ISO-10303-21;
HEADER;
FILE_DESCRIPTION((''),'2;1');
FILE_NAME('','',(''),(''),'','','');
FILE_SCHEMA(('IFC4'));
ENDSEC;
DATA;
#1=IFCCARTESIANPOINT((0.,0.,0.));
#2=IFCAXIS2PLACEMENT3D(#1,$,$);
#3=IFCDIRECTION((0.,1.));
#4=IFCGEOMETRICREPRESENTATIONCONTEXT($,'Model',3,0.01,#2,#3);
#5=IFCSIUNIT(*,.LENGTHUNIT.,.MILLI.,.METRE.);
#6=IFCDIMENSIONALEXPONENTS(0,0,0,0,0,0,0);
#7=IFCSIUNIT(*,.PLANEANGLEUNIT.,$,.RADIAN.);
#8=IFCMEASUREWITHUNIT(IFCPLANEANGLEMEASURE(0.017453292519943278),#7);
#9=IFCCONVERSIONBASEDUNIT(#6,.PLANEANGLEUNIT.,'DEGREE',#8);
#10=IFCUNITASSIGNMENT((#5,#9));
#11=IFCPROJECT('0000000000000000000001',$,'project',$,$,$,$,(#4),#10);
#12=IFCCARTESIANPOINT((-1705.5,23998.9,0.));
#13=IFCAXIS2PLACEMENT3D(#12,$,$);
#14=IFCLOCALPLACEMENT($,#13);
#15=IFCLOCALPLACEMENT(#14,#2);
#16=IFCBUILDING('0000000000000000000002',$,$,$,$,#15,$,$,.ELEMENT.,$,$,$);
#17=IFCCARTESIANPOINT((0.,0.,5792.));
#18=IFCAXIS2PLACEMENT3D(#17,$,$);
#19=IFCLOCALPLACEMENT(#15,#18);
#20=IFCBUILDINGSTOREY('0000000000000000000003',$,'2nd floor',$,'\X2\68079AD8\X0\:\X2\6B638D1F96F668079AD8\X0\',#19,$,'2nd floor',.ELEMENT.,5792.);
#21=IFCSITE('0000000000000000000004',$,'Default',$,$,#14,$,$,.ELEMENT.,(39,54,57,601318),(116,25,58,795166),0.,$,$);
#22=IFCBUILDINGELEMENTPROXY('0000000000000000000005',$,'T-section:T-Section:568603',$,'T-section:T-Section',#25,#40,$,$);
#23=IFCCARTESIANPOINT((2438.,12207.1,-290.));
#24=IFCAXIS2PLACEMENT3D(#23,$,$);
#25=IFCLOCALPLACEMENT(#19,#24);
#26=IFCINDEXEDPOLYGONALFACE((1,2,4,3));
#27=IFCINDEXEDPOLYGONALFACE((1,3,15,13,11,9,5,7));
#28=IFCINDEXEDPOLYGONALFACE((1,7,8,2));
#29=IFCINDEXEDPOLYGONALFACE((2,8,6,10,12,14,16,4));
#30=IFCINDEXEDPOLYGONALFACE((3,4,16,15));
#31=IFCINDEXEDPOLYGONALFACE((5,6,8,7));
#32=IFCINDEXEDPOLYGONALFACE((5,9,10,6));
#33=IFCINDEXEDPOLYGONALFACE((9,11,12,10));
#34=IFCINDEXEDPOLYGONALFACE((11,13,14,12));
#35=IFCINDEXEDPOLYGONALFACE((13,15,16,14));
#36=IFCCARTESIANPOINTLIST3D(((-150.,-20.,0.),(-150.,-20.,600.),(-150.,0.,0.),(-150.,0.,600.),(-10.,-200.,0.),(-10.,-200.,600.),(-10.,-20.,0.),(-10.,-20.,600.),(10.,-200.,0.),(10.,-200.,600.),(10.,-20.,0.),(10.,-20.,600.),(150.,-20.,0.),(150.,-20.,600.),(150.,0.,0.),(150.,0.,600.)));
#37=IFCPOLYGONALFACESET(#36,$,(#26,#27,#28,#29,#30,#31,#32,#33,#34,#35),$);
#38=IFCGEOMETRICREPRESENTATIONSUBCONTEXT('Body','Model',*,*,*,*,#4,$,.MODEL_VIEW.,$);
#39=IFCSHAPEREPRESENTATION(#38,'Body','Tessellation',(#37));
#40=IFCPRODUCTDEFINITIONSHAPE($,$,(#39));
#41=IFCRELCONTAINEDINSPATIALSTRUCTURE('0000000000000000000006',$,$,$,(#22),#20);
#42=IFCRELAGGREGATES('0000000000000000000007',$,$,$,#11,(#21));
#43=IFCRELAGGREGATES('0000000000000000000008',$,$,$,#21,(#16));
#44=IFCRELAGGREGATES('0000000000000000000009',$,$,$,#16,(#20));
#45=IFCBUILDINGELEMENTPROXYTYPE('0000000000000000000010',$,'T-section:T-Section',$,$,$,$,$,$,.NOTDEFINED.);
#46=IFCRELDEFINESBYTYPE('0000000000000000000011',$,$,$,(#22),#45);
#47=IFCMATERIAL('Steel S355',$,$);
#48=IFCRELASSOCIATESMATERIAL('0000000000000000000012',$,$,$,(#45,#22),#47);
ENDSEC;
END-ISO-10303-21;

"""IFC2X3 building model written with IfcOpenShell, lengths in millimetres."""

from ifc_helpers import new_model, entity, si_unit, converted_unit, direction, frame, origin, place, context, subcontext, project, spatial, polyline, outline, extrude, source, transform, mapped, material, type_object, type_shapes, element, save


model = new_model("IFC2X3")

# Units and contexts
model_context = context("Model", 3, precision=0.01, world=origin(), true_north=direction((0.0, 1.0)))
body_context = subcontext(model_context, "Body", "Model", "MODEL_VIEW")
ifc_project = project(units=[si_unit("LENGTHUNIT", "METRE", prefix="MILLI"), converted_unit("PLANEANGLEUNIT", "DEGREE", entity("IfcPlaneAngleMeasure", 0.017453292519943278), si_unit("PLANEANGLEUNIT", "RADIAN"), dimensions=[0, 0, 0, 0, 0, 0, 0])], contexts=[model_context])

# Site, building, storey
site_placement = place(None, frame((-1705.5, 23998.9, 0.0)))
site = spatial("IfcSite", under=ifc_project, at=site_placement, Name="Default", CompositionType="ELEMENT", RefLatitude=(39, 54, 57, 601318), RefLongitude=(116, 25, 58, 795166), RefElevation=0.0)
building_placement = place(site_placement, origin())
building = spatial("IfcBuilding", under=site, at=building_placement, CompositionType="ELEMENT")
storey_placement = place(building_placement, frame((0.0, 0.0, 5792.0)))
storey = spatial("IfcBuildingStorey", under=building, at=storey_placement, Name="2nd floor", ObjectType="标高:正负零标高", LongName="2nd floor", CompositionType="ELEMENT", Elevation=5792.0)

# Shared definitions
ifc_material_1 = material(Name="Steel S355")

# Building element proxy
building_element_proxy_type_1 = type_object("IfcBuildingElementProxyType", Name="T-section:T-Section", PredefinedType="NOTDEFINED", material=ifc_material_1)
shared_shape_1 = source(origin(), body_context, "Body", "SweptSolid", [
    extrude(outline(polyline([(-10.0, -140.0), (10.0, -140.0), (10.0, 40.0), (150.0, 40.0), (150.0, 60.0), (-150.0, 60.0), (-150.0, 40.0), (-10.0, 40.0), (-10.0, -140.0)])), frame((0.0, -60.0, 0.0)), (0.0, 0.0, 1.0), 600.0),
])
type_shapes(building_element_proxy_type_1, [shared_shape_1])
proxy_1_placement = place(storey_placement, frame((2438.0, 12207.1, -290.0)))
element("IfcBuildingElementProxy", 1, at=proxy_1_placement, inside=storey, type_object=building_element_proxy_type_1, material=ifc_material_1, Name="T-section:T-Section:568603", ObjectType="T-section:T-Section", context=body_context, shape_type="MappedRepresentation", body=[
    mapped(shared_shape_1, transform((0.0, 0.0, 0.0), scale=1.0)),
])

save(model, "model.ifc")
